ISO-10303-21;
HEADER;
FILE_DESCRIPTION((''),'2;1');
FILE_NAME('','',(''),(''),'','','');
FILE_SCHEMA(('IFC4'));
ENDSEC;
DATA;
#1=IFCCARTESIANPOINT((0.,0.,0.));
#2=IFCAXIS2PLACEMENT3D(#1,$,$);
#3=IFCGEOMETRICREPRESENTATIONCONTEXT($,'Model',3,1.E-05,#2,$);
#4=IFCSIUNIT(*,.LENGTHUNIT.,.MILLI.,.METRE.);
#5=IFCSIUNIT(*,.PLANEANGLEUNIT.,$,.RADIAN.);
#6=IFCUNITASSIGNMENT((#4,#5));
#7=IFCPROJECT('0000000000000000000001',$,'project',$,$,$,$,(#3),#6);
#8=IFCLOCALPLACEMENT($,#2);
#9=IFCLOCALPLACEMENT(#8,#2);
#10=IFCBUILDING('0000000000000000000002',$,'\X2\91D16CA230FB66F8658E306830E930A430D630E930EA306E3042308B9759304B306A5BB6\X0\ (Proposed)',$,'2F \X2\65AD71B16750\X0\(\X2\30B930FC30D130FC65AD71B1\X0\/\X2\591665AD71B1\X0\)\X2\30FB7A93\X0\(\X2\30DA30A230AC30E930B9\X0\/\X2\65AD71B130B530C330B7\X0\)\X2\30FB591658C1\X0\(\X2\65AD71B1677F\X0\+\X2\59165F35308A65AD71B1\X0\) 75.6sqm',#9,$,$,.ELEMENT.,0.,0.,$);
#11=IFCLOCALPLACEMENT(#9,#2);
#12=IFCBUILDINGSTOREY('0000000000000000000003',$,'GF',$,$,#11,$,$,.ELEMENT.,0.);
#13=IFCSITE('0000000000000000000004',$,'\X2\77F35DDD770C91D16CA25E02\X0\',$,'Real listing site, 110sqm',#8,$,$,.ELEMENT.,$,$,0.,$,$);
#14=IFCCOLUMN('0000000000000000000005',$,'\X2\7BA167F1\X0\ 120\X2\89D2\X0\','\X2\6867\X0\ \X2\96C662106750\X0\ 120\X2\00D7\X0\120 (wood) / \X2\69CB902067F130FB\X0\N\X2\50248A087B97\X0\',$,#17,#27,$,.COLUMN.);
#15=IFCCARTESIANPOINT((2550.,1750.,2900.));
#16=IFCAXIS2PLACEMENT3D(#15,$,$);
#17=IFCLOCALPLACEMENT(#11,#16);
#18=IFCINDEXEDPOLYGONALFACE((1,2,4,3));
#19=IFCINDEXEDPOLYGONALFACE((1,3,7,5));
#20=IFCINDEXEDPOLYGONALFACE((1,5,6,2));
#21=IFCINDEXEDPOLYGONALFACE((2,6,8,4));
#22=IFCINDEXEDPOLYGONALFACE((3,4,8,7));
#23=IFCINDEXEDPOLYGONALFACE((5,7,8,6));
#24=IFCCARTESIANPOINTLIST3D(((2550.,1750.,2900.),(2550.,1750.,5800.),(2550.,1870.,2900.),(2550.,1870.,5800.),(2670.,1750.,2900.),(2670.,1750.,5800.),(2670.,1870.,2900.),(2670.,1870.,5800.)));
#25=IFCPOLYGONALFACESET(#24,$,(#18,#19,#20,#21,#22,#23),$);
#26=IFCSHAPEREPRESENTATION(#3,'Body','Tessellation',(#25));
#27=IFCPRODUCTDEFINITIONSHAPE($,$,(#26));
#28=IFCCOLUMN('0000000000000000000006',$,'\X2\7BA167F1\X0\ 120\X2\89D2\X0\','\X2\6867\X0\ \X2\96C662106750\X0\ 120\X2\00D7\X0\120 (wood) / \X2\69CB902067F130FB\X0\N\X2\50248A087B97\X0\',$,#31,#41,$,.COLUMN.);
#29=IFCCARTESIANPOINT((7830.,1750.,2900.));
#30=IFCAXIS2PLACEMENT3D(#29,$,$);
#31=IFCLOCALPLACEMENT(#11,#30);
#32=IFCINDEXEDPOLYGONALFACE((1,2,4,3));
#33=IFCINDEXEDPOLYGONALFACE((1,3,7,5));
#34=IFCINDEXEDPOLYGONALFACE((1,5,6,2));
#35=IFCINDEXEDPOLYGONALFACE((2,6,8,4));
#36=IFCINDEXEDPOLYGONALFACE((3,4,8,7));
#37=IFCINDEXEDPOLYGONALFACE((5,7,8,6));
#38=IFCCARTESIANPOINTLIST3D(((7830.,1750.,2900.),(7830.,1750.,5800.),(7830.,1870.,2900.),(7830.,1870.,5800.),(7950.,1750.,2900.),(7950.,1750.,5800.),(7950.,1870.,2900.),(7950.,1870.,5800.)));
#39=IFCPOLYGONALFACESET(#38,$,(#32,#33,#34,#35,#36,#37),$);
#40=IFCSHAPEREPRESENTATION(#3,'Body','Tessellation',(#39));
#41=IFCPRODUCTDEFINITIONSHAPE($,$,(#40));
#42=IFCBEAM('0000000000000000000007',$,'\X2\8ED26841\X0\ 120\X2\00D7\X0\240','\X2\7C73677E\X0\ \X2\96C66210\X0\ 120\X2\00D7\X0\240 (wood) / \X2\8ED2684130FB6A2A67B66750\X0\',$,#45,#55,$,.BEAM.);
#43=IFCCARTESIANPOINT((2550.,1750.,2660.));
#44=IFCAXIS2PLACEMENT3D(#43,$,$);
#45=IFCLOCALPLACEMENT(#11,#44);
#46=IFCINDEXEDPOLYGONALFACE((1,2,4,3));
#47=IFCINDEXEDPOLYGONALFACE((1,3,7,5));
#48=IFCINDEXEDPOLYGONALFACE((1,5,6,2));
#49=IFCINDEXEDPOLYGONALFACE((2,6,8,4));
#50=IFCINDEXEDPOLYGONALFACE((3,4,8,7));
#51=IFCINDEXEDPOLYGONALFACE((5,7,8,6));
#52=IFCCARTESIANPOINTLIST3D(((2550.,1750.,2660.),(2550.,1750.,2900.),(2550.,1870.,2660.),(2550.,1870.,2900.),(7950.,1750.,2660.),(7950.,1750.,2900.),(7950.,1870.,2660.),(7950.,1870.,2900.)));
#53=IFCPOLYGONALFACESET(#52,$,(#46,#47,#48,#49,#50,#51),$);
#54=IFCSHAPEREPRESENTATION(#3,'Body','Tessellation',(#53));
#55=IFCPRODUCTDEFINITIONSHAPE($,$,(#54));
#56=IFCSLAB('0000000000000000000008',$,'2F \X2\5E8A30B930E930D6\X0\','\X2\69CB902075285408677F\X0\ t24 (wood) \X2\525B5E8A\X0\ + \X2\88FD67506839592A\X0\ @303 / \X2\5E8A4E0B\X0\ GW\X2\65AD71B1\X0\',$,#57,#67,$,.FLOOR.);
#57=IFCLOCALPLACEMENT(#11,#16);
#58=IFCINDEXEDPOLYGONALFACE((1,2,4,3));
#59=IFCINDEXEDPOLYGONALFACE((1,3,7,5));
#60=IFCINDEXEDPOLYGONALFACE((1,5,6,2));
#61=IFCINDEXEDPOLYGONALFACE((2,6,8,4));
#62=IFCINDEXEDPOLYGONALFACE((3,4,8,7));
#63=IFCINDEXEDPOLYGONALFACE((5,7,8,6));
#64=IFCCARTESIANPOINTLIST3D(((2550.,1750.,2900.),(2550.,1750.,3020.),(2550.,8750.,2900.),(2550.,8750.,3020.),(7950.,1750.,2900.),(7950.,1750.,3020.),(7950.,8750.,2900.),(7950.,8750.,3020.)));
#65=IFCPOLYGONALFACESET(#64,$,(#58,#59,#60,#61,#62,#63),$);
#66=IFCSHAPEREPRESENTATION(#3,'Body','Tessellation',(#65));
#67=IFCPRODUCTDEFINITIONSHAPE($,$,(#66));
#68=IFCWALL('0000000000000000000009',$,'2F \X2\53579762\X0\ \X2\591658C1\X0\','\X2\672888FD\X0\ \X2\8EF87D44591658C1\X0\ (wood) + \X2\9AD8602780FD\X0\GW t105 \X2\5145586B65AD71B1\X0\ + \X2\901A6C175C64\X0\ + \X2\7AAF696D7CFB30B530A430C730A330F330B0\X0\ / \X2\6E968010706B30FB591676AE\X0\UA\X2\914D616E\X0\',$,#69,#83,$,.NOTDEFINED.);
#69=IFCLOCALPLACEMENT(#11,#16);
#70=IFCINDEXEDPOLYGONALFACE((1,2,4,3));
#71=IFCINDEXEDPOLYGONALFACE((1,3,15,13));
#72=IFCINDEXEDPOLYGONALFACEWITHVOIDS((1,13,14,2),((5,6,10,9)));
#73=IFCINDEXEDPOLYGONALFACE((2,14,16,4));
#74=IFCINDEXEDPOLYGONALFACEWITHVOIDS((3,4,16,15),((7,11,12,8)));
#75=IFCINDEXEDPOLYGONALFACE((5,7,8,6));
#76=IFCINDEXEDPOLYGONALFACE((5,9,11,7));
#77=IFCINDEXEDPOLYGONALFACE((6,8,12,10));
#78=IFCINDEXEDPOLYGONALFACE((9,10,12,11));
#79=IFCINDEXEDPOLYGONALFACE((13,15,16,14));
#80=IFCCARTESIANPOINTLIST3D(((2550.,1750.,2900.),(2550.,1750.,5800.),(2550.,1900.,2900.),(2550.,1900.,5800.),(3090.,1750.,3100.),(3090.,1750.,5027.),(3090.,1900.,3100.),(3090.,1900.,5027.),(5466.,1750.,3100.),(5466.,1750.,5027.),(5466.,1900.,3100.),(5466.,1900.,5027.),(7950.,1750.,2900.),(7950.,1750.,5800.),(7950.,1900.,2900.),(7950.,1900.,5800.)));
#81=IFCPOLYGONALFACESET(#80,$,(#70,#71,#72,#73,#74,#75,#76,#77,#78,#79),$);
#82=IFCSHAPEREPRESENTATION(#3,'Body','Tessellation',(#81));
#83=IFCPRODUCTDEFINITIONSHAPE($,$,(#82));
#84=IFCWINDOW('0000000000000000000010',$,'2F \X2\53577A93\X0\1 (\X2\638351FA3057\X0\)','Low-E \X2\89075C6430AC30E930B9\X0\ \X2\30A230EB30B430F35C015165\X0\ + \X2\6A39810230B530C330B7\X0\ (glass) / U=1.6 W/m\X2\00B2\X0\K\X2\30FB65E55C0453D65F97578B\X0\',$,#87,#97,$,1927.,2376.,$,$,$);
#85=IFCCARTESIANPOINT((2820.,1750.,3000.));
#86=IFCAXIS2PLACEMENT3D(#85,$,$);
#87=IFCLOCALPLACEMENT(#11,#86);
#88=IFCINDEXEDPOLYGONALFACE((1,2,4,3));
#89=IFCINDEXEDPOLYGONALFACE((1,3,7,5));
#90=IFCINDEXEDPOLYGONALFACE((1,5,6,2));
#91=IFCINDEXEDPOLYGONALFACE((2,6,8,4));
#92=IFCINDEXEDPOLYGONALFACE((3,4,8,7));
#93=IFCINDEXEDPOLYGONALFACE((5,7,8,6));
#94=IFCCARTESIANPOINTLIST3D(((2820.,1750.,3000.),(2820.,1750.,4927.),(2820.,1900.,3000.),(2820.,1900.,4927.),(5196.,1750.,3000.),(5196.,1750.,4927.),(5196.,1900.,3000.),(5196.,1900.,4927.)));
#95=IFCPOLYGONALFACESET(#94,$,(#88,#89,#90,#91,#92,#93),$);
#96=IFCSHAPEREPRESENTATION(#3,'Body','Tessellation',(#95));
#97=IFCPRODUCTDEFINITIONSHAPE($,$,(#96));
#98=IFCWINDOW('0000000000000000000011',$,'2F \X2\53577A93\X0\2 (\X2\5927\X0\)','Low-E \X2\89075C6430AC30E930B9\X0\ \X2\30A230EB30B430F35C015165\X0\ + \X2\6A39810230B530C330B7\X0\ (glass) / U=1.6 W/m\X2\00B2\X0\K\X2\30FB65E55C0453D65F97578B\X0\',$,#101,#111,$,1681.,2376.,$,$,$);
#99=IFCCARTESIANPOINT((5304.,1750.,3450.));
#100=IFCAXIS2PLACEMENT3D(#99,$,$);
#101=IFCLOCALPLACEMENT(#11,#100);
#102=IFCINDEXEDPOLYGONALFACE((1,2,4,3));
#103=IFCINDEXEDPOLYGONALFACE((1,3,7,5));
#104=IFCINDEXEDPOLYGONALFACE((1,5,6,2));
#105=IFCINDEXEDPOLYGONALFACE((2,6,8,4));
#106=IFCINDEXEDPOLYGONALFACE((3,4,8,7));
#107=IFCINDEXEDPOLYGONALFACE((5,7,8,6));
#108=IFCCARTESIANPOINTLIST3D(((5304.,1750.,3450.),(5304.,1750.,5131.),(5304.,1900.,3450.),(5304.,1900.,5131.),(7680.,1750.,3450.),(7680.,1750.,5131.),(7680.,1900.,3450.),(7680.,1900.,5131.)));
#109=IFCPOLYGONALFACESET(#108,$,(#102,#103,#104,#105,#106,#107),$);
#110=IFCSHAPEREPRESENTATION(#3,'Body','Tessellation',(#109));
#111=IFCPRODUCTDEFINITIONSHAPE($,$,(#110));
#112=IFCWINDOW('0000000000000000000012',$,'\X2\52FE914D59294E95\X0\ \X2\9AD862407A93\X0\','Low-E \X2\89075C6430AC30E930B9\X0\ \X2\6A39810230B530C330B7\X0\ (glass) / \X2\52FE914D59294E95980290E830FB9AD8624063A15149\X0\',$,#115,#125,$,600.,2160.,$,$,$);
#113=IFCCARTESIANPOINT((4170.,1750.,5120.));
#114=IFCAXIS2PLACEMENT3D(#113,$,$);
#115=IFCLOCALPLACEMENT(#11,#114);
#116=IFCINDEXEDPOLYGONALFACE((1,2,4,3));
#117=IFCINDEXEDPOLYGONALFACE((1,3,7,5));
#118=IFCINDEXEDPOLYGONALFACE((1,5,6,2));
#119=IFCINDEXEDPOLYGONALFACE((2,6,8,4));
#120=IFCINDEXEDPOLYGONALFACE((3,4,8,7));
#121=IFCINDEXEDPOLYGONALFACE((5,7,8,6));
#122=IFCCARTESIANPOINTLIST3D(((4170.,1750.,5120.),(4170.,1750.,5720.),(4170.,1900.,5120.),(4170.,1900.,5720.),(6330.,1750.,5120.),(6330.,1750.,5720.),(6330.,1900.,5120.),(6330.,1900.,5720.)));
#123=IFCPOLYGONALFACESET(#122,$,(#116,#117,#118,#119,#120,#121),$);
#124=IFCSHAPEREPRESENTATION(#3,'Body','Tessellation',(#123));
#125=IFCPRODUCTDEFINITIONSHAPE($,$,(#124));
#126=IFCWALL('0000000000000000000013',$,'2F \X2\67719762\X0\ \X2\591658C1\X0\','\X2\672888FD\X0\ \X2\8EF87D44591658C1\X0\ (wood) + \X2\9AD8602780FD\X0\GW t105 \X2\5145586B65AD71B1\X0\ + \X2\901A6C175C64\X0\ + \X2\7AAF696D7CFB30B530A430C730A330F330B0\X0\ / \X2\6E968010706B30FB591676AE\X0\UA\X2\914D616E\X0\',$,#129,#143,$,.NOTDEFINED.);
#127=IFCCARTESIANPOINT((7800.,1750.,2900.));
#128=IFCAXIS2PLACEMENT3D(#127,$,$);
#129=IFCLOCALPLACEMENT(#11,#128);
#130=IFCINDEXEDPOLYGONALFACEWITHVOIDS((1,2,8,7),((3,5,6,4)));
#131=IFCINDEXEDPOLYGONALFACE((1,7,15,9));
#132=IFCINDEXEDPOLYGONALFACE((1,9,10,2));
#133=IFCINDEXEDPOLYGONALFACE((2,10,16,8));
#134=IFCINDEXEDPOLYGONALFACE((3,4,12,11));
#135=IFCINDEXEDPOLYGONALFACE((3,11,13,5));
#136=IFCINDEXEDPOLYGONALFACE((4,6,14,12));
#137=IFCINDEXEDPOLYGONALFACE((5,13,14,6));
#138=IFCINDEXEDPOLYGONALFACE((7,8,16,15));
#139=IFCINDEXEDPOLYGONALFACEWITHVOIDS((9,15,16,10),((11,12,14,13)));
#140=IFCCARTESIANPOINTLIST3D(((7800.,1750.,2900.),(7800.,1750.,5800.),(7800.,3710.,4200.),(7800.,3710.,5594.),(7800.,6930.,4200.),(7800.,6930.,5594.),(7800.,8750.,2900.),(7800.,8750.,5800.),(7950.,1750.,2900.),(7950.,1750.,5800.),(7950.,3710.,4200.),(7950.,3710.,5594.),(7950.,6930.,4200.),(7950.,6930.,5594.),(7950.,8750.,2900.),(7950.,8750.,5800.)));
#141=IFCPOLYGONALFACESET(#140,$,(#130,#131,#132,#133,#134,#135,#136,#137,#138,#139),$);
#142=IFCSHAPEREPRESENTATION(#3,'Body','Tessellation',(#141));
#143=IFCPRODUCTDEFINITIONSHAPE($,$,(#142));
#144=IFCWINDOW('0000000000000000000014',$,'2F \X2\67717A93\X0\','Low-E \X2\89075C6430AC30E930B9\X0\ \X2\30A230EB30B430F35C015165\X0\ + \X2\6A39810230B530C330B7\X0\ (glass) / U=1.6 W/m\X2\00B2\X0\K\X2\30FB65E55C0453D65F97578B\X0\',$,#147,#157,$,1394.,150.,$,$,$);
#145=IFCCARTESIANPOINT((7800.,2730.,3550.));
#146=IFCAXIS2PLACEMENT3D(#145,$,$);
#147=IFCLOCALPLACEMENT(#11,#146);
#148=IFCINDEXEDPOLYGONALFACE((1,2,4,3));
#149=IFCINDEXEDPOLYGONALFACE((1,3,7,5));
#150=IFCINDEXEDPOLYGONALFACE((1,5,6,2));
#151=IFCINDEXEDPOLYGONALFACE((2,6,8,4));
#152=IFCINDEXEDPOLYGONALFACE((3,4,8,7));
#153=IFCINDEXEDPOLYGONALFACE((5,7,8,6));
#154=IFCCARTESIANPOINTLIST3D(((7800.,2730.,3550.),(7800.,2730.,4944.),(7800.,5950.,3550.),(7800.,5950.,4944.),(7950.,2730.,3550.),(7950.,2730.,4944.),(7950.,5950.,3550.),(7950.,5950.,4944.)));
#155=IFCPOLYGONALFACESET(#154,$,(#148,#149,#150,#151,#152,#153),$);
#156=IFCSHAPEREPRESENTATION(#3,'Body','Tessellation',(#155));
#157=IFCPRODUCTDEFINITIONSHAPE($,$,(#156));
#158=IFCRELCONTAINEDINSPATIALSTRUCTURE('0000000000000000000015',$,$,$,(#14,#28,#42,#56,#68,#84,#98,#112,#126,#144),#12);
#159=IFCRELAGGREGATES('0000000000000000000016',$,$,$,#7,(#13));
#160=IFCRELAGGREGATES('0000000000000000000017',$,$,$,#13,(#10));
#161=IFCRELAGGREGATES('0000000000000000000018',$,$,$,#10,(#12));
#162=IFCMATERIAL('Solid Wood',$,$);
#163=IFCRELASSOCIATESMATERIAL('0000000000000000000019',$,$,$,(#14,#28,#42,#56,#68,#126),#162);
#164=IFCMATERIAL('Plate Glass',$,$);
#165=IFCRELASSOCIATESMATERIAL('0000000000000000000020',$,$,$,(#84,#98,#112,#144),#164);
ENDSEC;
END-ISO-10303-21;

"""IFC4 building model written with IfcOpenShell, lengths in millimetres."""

from ifc_helpers import new_model, si_unit, frame, frame_2d, origin, place, context, project, spatial, rectangle, extrude, material, element, fill, save


model = new_model("IFC4")

# Units and contexts
model_context = context("Model", 3, precision=1e-05, world=origin())
ifc_project = project(units=[si_unit("LENGTHUNIT", "METRE", prefix="MILLI"), si_unit("PLANEANGLEUNIT", "RADIAN")], contexts=[model_context])

# Site, building, storey
site_placement = place(None, origin())
site = spatial("IfcSite", under=ifc_project, at=site_placement, Name="石川県金沢市", ObjectType="Real listing site, 110sqm", CompositionType="ELEMENT", RefElevation=0.0)
building_placement = place(site_placement, origin())
building = spatial("IfcBuilding", under=site, at=building_placement, Name="金沢・書斎とライブラリのある静かな家 (Proposed)", ObjectType="2F 断熱材(スーパー断熱/外断熱)・窓(ペアガラス/断熱サッシ)・外壁(断熱板+外張り断熱) 75.6sqm", CompositionType="ELEMENT", ElevationOfRefHeight=0.0, ElevationOfTerrain=0.0)
storey_placement = place(building_placement, origin())
storey = spatial("IfcBuildingStorey", under=building, at=storey_placement, Name="GF", CompositionType="ELEMENT", Elevation=0.0)

# Columns
ifc_material_1 = material(Name="Solid Wood")
column_1_placement = place(storey_placement, frame((2550.0, 1750.0, 2900.0)))
element("IfcColumn", 1, at=column_1_placement, inside=storey, material=ifc_material_1, Name="管柱 120角", Description="桧 集成材 120×120 (wood) / 構造柱・N値計算", PredefinedType="COLUMN", context=model_context, shape_type="SweptSolid", body=[
    extrude(rectangle(XDim=120.0, YDim=120.0, at=frame_2d((60.0, 60.0))), frame((2550.0, 1750.0, 2900.0)), (0.0, 0.0, 1.0), 2900.0),
])
column_2_placement = place(storey_placement, frame((7830.0, 1750.0, 2900.0)))
element("IfcColumn", 2, at=column_2_placement, inside=storey, material=ifc_material_1, Name="管柱 120角", Description="桧 集成材 120×120 (wood) / 構造柱・N値計算", PredefinedType="COLUMN", context=model_context, shape_type="SweptSolid", body=[
    extrude(rectangle(XDim=120.0, YDim=120.0, at=frame_2d((60.0, 60.0))), frame((7830.0, 1750.0, 2900.0)), (0.0, 0.0, 1.0), 2900.0),
])

# Beam
beam_1_placement = place(storey_placement, frame((2550.0, 1750.0, 2660.0)))
element("IfcBeam", 3, at=beam_1_placement, inside=storey, material=ifc_material_1, Name="軒桁 120×240", Description="米松 集成 120×240 (wood) / 軒桁・横架材", PredefinedType="BEAM", context=model_context, shape_type="SweptSolid", body=[
    extrude(rectangle(XDim=5400.0, YDim=120.0, at=frame_2d((2700.0, 60.0))), frame((2550.0, 1750.0, 2660.0)), (0.0, 0.0, 1.0), 240.0),
])

# Slab
slab_placement = place(storey_placement, frame((2550.0, 1750.0, 2900.0)))
element("IfcSlab", 4, at=slab_placement, inside=storey, material=ifc_material_1, Name="2F 床スラブ", Description="構造用合板 t24 (wood) 剛床 + 製材根太 @303 / 床下 GW断熱", PredefinedType="FLOOR", context=model_context, shape_type="SweptSolid", body=[
    extrude(rectangle(XDim=5400.0, YDim=7000.0, at=frame_2d((2700.0, 3500.0))), frame((2550.0, 1750.0, 2900.0)), (0.0, 0.0, 1.0), 120.0),
])

# Wall, openings, windows
wall_1_placement = place(storey_placement, frame((2550.0, 1750.0, 2900.0)))
wall_1 = element("IfcWall", 5, at=wall_1_placement, inside=storey, material=ifc_material_1, Name="2F 南面 外壁", Description="木製 軸組外壁 (wood) + 高性能GW t105 充填断熱 + 通気層 + 窯業系サイディング / 準耐火・外皮UA配慮", PredefinedType="NOTDEFINED", context=model_context, shape_type="SweptSolid", body=[
    extrude(rectangle(XDim=5400.0, YDim=150.0, at=frame_2d((2700.0, 75.0))), frame((2550.0, 1750.0, 2900.0)), (0.0, 0.0, 1.0), 2900.0),
])
opening_1_placement = place(storey_placement, frame((2820.0, 1750.0, 3000.0)))
opening_1 = element("IfcOpeningElement", 6, at=opening_1_placement, cuts=wall_1, PredefinedType="NOTDEFINED", context=model_context, shape_type="SweptSolid", body=[
    extrude(rectangle(XDim=2376.0, YDim=150.0, at=frame_2d((1188.0, 75.0))), frame((2820.0, 1750.0, 3000.0)), (0.0, 0.0, 1.0), 1927.0),
])
opening_2_placement = place(storey_placement, frame((5304.0, 1750.0, 3450.0)))
opening_2 = element("IfcOpeningElement", 7, at=opening_2_placement, cuts=wall_1, PredefinedType="NOTDEFINED", context=model_context, shape_type="SweptSolid", body=[
    extrude(rectangle(XDim=2376.0, YDim=150.0, at=frame_2d((1188.0, 75.0))), frame((5304.0, 1750.0, 3450.0)), (0.0, 0.0, 1.0), 1681.0),
])
opening_3_placement = place(storey_placement, frame((4170.0, 1750.0, 5120.0)))
opening_3 = element("IfcOpeningElement", 8, at=opening_3_placement, cuts=wall_1, PredefinedType="NOTDEFINED", context=model_context, shape_type="SweptSolid", body=[
    extrude(rectangle(XDim=2160.0, YDim=150.0, at=frame_2d((1080.0, 75.0))), frame((4170.0, 1750.0, 5120.0)), (0.0, 0.0, 1.0), 600.0),
])
ifc_material_2 = material(Name="Plate Glass")
window_1_placement = place(storey_placement, frame((2820.0, 1750.0, 3000.0)))
window_1 = element("IfcWindow", 9, at=window_1_placement, inside=storey, material=ifc_material_2, Name="2F 南窓1 (掃出し)", Description="Low-E 複層ガラス アルゴン封入 + 樹脂サッシ (glass) / U=1.6 W/m²K・日射取得型", OverallHeight=1927.0, OverallWidth=2376.0, context=model_context, shape_type="SweptSolid", body=[
    extrude(rectangle(XDim=2376.0, YDim=150.0, at=frame_2d((1188.0, 75.0))), frame((2820.0, 1750.0, 3000.0)), (0.0, 0.0, 1.0), 1927.0),
])
fill(opening_1, window_1)
window_2_placement = place(storey_placement, frame((5304.0, 1750.0, 3450.0)))
window_2 = element("IfcWindow", 10, at=window_2_placement, inside=storey, material=ifc_material_2, Name="2F 南窓2 (大)", Description="Low-E 複層ガラス アルゴン封入 + 樹脂サッシ (glass) / U=1.6 W/m²K・日射取得型", OverallHeight=1681.0, OverallWidth=2376.0, context=model_context, shape_type="SweptSolid", body=[
    extrude(rectangle(XDim=2376.0, YDim=150.0, at=frame_2d((1188.0, 75.0))), frame((5304.0, 1750.0, 3450.0)), (0.0, 0.0, 1.0), 1681.0),
])
fill(opening_2, window_2)
window_3_placement = place(storey_placement, frame((4170.0, 1750.0, 5120.0)))
window_3 = element("IfcWindow", 11, at=window_3_placement, inside=storey, material=ifc_material_2, Name="勾配天井 高所窓", Description="Low-E 複層ガラス 樹脂サッシ (glass) / 勾配天井頂部・高所採光", OverallHeight=600.0, OverallWidth=2160.0, context=model_context, shape_type="SweptSolid", body=[
    extrude(rectangle(XDim=2160.0, YDim=150.0, at=frame_2d((1080.0, 75.0))), frame((4170.0, 1750.0, 5120.0)), (0.0, 0.0, 1.0), 600.0),
])
fill(opening_3, window_3)

# Wall, opening, window
wall_2_placement = place(storey_placement, frame((7800.0, 1750.0, 2900.0)))
wall_2 = element("IfcWall", 12, at=wall_2_placement, inside=storey, material=ifc_material_1, Name="2F 東面 外壁", Description="木製 軸組外壁 (wood) + 高性能GW t105 充填断熱 + 通気層 + 窯業系サイディング / 準耐火・外皮UA配慮", PredefinedType="NOTDEFINED", context=model_context, shape_type="SweptSolid", body=[
    extrude(rectangle(XDim=150.0, YDim=7000.0, at=frame_2d((75.0, 3500.0))), frame((7800.0, 1750.0, 2900.0)), (0.0, 0.0, 1.0), 2900.0),
])
opening_4_placement = place(storey_placement, frame((7800.0, 2730.0, 3550.0)))
opening_4 = element("IfcOpeningElement", 13, at=opening_4_placement, cuts=wall_2, PredefinedType="NOTDEFINED", context=model_context, shape_type="SweptSolid", body=[
    extrude(rectangle(XDim=150.0, YDim=3220.0, at=frame_2d((75.0, 1610.0))), frame((7800.0, 2730.0, 3550.0)), (0.0, 0.0, 1.0), 1394.0),
])
window_4_placement = place(storey_placement, frame((7800.0, 2730.0, 3550.0)))
window_4 = element("IfcWindow", 14, at=window_4_placement, inside=storey, material=ifc_material_2, Name="2F 東窓", Description="Low-E 複層ガラス アルゴン封入 + 樹脂サッシ (glass) / U=1.6 W/m²K・日射取得型", OverallHeight=1394.0, OverallWidth=150.0, context=model_context, shape_type="SweptSolid", body=[
    extrude(rectangle(XDim=150.0, YDim=3220.0, at=frame_2d((75.0, 1610.0))), frame((7800.0, 2730.0, 3550.0)), (0.0, 0.0, 1.0), 1394.0),
])
fill(opening_4, window_4)

save(model, "model.ifc")
